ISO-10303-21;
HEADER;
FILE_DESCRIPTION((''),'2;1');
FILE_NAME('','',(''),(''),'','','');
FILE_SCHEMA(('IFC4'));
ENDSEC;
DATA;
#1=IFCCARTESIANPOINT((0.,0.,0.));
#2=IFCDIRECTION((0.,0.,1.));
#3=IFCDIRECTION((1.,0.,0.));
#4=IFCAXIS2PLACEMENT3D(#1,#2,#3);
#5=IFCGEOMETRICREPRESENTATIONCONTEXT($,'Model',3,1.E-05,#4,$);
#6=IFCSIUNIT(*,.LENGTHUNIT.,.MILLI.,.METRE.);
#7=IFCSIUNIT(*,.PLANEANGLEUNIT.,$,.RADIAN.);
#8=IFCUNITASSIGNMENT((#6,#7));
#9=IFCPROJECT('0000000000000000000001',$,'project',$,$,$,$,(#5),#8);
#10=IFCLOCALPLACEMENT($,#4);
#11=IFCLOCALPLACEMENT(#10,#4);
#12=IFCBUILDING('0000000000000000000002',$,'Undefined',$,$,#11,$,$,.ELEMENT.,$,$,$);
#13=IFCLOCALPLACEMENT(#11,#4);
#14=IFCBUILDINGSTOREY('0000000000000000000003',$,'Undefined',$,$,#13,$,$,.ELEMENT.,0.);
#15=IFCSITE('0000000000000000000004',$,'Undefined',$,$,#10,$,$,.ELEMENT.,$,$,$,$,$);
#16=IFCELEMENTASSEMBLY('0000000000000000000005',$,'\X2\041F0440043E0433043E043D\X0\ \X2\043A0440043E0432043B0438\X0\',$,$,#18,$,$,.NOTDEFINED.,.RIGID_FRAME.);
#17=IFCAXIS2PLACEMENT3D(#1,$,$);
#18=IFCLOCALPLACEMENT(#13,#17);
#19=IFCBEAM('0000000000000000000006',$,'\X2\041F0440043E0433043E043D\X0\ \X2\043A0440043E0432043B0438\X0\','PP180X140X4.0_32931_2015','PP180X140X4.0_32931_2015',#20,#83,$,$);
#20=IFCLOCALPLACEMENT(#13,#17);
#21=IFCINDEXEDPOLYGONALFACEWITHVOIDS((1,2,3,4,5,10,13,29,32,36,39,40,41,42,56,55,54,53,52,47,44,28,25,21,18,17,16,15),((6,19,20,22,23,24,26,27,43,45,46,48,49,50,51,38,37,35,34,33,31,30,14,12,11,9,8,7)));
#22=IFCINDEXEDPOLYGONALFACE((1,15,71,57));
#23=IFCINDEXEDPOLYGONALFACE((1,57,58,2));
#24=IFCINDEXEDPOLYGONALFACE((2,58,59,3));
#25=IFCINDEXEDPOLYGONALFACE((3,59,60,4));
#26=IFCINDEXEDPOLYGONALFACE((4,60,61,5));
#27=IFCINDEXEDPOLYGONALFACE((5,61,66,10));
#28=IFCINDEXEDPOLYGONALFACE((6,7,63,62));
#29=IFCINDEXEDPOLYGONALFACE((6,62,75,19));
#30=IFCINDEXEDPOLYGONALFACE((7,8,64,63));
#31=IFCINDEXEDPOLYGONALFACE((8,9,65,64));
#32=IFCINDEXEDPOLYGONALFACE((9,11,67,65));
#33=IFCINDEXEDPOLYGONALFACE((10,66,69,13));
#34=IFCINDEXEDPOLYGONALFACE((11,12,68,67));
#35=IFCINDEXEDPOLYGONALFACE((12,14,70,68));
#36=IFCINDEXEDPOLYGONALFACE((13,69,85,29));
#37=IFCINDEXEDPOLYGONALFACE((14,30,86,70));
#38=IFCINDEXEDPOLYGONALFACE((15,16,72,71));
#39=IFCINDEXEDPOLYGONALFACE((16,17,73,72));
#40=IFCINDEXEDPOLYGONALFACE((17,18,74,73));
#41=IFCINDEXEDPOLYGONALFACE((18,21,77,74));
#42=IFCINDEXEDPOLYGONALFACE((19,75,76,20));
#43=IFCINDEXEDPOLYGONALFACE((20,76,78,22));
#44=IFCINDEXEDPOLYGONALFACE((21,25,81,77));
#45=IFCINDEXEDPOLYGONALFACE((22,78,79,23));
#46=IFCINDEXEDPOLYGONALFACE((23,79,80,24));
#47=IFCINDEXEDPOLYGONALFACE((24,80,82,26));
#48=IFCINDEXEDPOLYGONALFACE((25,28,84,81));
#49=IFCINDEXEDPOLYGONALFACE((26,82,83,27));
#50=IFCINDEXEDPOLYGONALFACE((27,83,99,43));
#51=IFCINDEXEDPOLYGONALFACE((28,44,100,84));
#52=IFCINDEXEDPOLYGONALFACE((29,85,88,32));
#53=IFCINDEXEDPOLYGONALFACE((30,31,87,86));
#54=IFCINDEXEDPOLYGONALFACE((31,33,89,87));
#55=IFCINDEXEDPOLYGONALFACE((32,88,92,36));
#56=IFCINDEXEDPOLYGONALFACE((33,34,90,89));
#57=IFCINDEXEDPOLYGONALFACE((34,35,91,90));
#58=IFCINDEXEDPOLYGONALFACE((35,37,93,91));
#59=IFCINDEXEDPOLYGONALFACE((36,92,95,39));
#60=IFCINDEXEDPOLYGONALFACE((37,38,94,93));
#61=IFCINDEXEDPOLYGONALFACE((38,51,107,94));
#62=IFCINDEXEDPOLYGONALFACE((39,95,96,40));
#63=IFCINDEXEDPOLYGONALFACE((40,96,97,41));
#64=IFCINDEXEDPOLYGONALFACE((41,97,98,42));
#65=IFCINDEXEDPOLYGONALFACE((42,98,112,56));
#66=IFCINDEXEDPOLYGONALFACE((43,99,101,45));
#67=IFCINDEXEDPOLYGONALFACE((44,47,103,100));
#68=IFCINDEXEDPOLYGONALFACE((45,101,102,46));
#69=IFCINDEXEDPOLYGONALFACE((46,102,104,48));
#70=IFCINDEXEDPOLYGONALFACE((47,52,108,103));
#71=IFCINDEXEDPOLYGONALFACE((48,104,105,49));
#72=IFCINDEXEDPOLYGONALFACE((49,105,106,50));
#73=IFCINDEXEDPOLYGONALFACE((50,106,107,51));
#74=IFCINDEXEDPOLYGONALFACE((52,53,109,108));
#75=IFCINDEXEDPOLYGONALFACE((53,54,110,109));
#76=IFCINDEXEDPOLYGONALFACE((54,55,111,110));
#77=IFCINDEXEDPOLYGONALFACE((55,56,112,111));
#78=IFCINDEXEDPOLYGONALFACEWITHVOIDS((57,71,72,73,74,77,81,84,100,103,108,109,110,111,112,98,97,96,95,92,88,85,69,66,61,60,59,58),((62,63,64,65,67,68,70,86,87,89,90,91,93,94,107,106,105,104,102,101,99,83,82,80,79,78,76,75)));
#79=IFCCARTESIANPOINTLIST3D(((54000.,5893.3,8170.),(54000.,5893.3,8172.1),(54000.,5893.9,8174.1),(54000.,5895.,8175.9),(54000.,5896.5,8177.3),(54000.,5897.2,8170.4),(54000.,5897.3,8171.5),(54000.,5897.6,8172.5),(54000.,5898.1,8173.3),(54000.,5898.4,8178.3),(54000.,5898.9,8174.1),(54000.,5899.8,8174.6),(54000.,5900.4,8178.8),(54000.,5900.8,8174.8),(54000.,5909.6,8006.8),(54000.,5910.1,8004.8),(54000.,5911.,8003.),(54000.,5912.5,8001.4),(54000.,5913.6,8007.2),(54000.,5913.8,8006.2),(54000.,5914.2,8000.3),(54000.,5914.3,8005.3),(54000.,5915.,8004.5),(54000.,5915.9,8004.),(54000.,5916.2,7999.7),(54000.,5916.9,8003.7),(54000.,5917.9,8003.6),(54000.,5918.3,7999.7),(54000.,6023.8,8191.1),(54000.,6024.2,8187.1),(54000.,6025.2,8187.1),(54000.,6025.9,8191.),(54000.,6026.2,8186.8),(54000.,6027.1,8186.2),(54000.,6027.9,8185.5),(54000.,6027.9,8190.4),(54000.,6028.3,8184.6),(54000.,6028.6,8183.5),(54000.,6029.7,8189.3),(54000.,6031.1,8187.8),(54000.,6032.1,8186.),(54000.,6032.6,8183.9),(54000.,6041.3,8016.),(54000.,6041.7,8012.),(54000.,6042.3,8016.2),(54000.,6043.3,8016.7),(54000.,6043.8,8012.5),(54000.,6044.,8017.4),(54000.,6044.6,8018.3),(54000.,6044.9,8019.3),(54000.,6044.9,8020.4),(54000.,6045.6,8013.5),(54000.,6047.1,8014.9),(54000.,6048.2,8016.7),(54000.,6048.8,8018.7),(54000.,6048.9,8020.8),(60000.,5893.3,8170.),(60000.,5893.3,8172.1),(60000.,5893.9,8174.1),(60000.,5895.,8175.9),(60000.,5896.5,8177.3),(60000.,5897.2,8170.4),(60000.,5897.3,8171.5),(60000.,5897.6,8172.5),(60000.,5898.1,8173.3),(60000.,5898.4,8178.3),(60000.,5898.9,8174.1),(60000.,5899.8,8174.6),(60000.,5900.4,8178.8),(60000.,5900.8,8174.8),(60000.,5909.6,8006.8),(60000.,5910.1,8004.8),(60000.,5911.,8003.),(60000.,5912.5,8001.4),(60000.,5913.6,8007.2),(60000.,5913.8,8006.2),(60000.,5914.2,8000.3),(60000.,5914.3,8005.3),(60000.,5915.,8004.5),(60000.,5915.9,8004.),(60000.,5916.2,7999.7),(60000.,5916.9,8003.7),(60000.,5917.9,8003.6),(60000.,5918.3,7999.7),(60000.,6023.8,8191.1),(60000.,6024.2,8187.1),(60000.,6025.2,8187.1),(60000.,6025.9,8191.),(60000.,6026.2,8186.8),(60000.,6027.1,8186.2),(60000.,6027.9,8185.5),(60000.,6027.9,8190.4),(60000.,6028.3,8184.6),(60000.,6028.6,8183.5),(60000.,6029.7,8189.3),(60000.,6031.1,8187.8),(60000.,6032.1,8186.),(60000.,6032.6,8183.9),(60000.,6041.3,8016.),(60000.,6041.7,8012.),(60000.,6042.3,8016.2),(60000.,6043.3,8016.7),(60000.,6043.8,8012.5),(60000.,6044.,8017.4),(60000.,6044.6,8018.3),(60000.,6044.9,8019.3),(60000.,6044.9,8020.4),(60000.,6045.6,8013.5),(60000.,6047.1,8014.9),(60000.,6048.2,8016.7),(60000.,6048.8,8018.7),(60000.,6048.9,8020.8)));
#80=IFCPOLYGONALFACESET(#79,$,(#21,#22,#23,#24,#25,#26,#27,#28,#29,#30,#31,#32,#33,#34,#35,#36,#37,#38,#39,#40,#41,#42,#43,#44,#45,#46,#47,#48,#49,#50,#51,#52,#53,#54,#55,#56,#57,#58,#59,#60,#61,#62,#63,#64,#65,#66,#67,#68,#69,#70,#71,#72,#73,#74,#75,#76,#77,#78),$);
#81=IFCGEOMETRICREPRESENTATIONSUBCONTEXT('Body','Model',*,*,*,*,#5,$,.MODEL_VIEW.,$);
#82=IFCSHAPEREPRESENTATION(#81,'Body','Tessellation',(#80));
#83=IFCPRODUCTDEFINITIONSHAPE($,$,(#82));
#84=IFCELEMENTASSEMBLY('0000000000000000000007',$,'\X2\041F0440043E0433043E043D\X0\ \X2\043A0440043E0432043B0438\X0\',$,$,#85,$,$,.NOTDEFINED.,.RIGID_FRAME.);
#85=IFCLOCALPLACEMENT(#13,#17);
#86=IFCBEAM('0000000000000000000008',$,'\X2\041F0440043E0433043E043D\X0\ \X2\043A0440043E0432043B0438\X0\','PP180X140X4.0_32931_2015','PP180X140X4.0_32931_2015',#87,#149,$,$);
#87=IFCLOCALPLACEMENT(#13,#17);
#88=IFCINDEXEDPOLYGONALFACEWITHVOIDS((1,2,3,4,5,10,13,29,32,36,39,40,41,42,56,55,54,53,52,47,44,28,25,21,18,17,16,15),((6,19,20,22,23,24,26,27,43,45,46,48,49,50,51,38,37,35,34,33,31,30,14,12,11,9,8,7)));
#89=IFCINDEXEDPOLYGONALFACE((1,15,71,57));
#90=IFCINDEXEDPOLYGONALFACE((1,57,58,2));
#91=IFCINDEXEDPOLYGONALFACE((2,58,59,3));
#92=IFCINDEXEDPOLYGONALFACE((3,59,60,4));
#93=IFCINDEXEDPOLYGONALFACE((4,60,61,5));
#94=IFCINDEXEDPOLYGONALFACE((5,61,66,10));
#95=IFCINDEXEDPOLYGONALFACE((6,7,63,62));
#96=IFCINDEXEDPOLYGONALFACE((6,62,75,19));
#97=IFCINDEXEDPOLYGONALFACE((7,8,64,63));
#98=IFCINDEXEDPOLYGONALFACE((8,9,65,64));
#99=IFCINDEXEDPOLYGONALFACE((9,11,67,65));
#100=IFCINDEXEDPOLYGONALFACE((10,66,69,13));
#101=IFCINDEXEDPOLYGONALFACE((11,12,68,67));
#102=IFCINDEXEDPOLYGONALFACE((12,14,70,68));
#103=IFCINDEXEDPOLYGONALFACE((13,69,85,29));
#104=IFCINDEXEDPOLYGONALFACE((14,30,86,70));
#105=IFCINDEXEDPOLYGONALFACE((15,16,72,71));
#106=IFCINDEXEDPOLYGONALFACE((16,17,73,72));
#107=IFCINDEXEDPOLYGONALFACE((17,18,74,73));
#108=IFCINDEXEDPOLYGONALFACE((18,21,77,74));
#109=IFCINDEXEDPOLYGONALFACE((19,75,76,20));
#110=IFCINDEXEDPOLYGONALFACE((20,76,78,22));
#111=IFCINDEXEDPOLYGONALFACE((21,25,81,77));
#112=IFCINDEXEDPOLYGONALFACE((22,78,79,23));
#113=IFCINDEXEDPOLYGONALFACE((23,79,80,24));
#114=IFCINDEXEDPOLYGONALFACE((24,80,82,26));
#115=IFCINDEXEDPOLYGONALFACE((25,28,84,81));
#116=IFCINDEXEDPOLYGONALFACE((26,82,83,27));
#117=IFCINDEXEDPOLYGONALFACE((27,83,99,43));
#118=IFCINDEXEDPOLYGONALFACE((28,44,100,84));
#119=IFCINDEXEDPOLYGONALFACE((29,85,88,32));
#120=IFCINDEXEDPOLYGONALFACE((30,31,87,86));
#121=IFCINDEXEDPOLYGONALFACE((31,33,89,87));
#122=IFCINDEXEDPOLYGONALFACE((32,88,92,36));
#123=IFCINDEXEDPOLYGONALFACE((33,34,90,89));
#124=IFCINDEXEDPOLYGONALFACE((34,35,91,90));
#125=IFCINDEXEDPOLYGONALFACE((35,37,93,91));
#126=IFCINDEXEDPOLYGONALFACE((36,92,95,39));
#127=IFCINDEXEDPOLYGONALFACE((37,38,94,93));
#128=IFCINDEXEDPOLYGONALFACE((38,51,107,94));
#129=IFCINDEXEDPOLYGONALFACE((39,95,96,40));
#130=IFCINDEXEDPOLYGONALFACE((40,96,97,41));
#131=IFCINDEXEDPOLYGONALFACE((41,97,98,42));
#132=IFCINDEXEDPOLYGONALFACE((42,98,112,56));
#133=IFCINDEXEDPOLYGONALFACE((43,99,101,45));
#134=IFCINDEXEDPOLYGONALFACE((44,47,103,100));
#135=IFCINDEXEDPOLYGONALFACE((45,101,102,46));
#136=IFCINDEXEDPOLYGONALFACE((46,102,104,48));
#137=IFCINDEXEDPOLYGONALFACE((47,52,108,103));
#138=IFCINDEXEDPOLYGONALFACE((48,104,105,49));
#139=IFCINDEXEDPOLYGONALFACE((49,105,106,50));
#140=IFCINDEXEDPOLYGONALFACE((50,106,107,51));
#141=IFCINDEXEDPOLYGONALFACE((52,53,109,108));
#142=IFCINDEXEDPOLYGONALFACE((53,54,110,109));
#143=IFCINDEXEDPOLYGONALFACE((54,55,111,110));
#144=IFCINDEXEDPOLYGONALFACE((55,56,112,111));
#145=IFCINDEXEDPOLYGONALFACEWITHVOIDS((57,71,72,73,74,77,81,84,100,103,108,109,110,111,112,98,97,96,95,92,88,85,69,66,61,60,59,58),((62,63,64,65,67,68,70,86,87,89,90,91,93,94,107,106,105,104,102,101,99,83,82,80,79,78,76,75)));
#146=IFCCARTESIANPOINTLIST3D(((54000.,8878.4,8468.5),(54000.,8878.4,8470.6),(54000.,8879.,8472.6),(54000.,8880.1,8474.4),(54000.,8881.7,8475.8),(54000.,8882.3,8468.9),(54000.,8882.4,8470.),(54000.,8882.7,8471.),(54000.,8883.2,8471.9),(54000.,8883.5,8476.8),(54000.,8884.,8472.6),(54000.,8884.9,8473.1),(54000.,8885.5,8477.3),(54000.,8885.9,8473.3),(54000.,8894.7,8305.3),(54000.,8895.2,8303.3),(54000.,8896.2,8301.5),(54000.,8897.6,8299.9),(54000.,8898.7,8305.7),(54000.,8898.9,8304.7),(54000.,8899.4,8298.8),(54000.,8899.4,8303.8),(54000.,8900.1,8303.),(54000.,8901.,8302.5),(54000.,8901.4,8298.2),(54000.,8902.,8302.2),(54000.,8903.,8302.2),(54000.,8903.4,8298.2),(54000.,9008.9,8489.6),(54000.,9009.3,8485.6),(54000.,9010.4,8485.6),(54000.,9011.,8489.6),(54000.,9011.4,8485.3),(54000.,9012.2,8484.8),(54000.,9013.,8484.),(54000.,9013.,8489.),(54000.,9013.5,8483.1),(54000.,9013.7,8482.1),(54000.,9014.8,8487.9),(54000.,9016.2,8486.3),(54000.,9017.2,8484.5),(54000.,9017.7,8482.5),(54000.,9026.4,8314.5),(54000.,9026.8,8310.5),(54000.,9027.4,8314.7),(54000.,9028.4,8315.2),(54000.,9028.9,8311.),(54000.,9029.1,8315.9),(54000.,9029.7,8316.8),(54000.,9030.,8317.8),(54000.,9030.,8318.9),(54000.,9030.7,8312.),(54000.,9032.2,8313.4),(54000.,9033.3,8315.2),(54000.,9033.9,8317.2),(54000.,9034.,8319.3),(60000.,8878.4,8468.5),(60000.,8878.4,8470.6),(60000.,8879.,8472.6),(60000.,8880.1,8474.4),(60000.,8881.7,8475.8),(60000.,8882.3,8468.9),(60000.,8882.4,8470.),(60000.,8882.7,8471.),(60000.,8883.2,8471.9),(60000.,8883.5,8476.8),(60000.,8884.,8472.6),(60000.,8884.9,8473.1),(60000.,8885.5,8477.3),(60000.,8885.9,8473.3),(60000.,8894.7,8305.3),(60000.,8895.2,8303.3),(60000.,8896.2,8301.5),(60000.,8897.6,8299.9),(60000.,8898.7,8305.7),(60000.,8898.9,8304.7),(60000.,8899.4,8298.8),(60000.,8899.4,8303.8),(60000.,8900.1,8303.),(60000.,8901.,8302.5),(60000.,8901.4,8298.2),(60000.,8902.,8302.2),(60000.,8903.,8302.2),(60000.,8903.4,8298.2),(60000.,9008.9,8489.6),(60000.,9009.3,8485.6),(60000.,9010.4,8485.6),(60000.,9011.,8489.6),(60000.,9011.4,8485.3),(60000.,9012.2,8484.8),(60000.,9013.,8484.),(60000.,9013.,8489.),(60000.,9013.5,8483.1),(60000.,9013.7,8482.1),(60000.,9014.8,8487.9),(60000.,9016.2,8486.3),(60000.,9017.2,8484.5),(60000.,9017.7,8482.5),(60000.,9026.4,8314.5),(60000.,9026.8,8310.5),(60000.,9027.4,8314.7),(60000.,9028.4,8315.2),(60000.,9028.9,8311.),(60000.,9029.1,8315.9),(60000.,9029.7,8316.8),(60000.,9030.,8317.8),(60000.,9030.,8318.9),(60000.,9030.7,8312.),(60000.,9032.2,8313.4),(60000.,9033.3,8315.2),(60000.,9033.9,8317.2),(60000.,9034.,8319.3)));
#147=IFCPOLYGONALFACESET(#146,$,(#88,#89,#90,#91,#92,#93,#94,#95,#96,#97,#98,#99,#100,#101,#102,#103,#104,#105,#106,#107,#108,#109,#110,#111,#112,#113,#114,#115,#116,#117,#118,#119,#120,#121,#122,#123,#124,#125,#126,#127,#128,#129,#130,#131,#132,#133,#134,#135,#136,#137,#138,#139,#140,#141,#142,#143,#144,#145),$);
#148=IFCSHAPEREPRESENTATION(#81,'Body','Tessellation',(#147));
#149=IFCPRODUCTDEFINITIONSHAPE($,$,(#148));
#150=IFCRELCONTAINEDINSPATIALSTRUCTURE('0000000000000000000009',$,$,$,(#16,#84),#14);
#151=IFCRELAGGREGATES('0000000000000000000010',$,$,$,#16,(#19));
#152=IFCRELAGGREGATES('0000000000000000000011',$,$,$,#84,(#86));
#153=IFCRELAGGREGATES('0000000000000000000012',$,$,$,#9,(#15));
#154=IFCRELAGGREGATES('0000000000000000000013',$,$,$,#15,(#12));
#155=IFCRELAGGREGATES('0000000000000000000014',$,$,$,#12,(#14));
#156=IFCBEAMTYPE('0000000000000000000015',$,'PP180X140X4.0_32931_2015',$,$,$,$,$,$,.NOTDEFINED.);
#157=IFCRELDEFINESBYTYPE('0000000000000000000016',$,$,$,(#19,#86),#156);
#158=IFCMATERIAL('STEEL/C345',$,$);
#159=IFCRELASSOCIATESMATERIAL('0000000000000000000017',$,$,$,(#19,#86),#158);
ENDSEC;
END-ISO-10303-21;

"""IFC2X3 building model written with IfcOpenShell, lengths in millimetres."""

from ifc_helpers import new_model, si_unit, frame, origin_with_axes, origin_2d_with_axis, place, context, subcontext, project, spatial, hollow_rectangle, extrude, material, type_object, element, aggregate, save


model = new_model("IFC2X3")

# Units and contexts
model_context = context("Model", 3, precision=1e-05, world=origin_with_axes())
body_context = subcontext(model_context, "Body", "Model", "MODEL_VIEW")
ifc_project = project(units=[si_unit("LENGTHUNIT", "METRE", prefix="MILLI"), si_unit("PLANEANGLEUNIT", "RADIAN")], contexts=[model_context])

# Site, building, storey
site_placement = place(None, origin_with_axes())
site = spatial("IfcSite", under=ifc_project, at=site_placement, Name="Undefined", CompositionType="ELEMENT")
building_placement = place(site_placement, origin_with_axes())
building = spatial("IfcBuilding", under=site, at=building_placement, Name="Undefined", CompositionType="ELEMENT")
storey_placement = place(building_placement, origin_with_axes())
storey = spatial("IfcBuildingStorey", under=building, at=storey_placement, Name="Undefined", CompositionType="ELEMENT", Elevation=0.0)

# Shared definitions
ifc_material_1 = material(Name="STEEL/C345")

# Element assemblies, beams
beam_type_1 = type_object("IfcBeamType", Name="PP180X140X4.0_32931_2015", PredefinedType="NOTDEFINED")
assembly_1_placement = place(storey_placement, origin_with_axes())
assembly_1 = element("IfcElementAssembly", 1, at=assembly_1_placement, inside=storey, Name="Прогон кровли", AssemblyPlace="NOTDEFINED", PredefinedType="RIGID_FRAME")
beam_1_placement = place(assembly_1_placement, frame((54000.0, 5971.1, 8095.4), z_axis=(0.0, -0.099504, 0.995037), x_axis=(1.0, 0.0, 0.0)))
beam_1 = element("IfcBeam", 2, at=beam_1_placement, type_object=beam_type_1, material=ifc_material_1, Name="Прогон кровли", Description="PP180X140X4.0_32931_2015", ObjectType="PP180X140X4.0_32931_2015", context=body_context, shape_type="SweptSolid", body=[
    extrude(hollow_rectangle(XDim=140.0, YDim=180.0, WallThickness=4.0, InnerFilletRadius=4.0, OuterFilletRadius=8.0, at=origin_2d_with_axis()), frame((6000.0, 0.0, 0.0), z_axis=(-1.0, 0.0, 0.0), x_axis=(0.0, -1.0, 0.0)), (0.0, 0.0, 1.0), 6000.0),
])
aggregate(assembly_1, [beam_1])
assembly_2_placement = place(storey_placement, origin_with_axes())
assembly_2 = element("IfcElementAssembly", 3, at=assembly_2_placement, inside=storey, Name="Прогон кровли", AssemblyPlace="NOTDEFINED", PredefinedType="RIGID_FRAME")
beam_2_placement = place(assembly_2_placement, frame((54000.0, 8956.2, 8393.9), z_axis=(0.0, -0.099504, 0.995037), x_axis=(1.0, 0.0, 0.0)))
beam_2 = element("IfcBeam", 4, at=beam_2_placement, type_object=beam_type_1, material=ifc_material_1, Name="Прогон кровли", Description="PP180X140X4.0_32931_2015", ObjectType="PP180X140X4.0_32931_2015", context=body_context, shape_type="SweptSolid", body=[
    extrude(hollow_rectangle(XDim=140.0, YDim=180.0, WallThickness=4.0, InnerFilletRadius=4.0, OuterFilletRadius=8.0, at=origin_2d_with_axis()), frame((6000.0, 0.0, 0.0), z_axis=(-1.0, 0.0, 0.0), x_axis=(0.0, -1.0, 0.0)), (0.0, 0.0, 1.0), 6000.0),
])
aggregate(assembly_2, [beam_2])

save(model, "model.ifc")
